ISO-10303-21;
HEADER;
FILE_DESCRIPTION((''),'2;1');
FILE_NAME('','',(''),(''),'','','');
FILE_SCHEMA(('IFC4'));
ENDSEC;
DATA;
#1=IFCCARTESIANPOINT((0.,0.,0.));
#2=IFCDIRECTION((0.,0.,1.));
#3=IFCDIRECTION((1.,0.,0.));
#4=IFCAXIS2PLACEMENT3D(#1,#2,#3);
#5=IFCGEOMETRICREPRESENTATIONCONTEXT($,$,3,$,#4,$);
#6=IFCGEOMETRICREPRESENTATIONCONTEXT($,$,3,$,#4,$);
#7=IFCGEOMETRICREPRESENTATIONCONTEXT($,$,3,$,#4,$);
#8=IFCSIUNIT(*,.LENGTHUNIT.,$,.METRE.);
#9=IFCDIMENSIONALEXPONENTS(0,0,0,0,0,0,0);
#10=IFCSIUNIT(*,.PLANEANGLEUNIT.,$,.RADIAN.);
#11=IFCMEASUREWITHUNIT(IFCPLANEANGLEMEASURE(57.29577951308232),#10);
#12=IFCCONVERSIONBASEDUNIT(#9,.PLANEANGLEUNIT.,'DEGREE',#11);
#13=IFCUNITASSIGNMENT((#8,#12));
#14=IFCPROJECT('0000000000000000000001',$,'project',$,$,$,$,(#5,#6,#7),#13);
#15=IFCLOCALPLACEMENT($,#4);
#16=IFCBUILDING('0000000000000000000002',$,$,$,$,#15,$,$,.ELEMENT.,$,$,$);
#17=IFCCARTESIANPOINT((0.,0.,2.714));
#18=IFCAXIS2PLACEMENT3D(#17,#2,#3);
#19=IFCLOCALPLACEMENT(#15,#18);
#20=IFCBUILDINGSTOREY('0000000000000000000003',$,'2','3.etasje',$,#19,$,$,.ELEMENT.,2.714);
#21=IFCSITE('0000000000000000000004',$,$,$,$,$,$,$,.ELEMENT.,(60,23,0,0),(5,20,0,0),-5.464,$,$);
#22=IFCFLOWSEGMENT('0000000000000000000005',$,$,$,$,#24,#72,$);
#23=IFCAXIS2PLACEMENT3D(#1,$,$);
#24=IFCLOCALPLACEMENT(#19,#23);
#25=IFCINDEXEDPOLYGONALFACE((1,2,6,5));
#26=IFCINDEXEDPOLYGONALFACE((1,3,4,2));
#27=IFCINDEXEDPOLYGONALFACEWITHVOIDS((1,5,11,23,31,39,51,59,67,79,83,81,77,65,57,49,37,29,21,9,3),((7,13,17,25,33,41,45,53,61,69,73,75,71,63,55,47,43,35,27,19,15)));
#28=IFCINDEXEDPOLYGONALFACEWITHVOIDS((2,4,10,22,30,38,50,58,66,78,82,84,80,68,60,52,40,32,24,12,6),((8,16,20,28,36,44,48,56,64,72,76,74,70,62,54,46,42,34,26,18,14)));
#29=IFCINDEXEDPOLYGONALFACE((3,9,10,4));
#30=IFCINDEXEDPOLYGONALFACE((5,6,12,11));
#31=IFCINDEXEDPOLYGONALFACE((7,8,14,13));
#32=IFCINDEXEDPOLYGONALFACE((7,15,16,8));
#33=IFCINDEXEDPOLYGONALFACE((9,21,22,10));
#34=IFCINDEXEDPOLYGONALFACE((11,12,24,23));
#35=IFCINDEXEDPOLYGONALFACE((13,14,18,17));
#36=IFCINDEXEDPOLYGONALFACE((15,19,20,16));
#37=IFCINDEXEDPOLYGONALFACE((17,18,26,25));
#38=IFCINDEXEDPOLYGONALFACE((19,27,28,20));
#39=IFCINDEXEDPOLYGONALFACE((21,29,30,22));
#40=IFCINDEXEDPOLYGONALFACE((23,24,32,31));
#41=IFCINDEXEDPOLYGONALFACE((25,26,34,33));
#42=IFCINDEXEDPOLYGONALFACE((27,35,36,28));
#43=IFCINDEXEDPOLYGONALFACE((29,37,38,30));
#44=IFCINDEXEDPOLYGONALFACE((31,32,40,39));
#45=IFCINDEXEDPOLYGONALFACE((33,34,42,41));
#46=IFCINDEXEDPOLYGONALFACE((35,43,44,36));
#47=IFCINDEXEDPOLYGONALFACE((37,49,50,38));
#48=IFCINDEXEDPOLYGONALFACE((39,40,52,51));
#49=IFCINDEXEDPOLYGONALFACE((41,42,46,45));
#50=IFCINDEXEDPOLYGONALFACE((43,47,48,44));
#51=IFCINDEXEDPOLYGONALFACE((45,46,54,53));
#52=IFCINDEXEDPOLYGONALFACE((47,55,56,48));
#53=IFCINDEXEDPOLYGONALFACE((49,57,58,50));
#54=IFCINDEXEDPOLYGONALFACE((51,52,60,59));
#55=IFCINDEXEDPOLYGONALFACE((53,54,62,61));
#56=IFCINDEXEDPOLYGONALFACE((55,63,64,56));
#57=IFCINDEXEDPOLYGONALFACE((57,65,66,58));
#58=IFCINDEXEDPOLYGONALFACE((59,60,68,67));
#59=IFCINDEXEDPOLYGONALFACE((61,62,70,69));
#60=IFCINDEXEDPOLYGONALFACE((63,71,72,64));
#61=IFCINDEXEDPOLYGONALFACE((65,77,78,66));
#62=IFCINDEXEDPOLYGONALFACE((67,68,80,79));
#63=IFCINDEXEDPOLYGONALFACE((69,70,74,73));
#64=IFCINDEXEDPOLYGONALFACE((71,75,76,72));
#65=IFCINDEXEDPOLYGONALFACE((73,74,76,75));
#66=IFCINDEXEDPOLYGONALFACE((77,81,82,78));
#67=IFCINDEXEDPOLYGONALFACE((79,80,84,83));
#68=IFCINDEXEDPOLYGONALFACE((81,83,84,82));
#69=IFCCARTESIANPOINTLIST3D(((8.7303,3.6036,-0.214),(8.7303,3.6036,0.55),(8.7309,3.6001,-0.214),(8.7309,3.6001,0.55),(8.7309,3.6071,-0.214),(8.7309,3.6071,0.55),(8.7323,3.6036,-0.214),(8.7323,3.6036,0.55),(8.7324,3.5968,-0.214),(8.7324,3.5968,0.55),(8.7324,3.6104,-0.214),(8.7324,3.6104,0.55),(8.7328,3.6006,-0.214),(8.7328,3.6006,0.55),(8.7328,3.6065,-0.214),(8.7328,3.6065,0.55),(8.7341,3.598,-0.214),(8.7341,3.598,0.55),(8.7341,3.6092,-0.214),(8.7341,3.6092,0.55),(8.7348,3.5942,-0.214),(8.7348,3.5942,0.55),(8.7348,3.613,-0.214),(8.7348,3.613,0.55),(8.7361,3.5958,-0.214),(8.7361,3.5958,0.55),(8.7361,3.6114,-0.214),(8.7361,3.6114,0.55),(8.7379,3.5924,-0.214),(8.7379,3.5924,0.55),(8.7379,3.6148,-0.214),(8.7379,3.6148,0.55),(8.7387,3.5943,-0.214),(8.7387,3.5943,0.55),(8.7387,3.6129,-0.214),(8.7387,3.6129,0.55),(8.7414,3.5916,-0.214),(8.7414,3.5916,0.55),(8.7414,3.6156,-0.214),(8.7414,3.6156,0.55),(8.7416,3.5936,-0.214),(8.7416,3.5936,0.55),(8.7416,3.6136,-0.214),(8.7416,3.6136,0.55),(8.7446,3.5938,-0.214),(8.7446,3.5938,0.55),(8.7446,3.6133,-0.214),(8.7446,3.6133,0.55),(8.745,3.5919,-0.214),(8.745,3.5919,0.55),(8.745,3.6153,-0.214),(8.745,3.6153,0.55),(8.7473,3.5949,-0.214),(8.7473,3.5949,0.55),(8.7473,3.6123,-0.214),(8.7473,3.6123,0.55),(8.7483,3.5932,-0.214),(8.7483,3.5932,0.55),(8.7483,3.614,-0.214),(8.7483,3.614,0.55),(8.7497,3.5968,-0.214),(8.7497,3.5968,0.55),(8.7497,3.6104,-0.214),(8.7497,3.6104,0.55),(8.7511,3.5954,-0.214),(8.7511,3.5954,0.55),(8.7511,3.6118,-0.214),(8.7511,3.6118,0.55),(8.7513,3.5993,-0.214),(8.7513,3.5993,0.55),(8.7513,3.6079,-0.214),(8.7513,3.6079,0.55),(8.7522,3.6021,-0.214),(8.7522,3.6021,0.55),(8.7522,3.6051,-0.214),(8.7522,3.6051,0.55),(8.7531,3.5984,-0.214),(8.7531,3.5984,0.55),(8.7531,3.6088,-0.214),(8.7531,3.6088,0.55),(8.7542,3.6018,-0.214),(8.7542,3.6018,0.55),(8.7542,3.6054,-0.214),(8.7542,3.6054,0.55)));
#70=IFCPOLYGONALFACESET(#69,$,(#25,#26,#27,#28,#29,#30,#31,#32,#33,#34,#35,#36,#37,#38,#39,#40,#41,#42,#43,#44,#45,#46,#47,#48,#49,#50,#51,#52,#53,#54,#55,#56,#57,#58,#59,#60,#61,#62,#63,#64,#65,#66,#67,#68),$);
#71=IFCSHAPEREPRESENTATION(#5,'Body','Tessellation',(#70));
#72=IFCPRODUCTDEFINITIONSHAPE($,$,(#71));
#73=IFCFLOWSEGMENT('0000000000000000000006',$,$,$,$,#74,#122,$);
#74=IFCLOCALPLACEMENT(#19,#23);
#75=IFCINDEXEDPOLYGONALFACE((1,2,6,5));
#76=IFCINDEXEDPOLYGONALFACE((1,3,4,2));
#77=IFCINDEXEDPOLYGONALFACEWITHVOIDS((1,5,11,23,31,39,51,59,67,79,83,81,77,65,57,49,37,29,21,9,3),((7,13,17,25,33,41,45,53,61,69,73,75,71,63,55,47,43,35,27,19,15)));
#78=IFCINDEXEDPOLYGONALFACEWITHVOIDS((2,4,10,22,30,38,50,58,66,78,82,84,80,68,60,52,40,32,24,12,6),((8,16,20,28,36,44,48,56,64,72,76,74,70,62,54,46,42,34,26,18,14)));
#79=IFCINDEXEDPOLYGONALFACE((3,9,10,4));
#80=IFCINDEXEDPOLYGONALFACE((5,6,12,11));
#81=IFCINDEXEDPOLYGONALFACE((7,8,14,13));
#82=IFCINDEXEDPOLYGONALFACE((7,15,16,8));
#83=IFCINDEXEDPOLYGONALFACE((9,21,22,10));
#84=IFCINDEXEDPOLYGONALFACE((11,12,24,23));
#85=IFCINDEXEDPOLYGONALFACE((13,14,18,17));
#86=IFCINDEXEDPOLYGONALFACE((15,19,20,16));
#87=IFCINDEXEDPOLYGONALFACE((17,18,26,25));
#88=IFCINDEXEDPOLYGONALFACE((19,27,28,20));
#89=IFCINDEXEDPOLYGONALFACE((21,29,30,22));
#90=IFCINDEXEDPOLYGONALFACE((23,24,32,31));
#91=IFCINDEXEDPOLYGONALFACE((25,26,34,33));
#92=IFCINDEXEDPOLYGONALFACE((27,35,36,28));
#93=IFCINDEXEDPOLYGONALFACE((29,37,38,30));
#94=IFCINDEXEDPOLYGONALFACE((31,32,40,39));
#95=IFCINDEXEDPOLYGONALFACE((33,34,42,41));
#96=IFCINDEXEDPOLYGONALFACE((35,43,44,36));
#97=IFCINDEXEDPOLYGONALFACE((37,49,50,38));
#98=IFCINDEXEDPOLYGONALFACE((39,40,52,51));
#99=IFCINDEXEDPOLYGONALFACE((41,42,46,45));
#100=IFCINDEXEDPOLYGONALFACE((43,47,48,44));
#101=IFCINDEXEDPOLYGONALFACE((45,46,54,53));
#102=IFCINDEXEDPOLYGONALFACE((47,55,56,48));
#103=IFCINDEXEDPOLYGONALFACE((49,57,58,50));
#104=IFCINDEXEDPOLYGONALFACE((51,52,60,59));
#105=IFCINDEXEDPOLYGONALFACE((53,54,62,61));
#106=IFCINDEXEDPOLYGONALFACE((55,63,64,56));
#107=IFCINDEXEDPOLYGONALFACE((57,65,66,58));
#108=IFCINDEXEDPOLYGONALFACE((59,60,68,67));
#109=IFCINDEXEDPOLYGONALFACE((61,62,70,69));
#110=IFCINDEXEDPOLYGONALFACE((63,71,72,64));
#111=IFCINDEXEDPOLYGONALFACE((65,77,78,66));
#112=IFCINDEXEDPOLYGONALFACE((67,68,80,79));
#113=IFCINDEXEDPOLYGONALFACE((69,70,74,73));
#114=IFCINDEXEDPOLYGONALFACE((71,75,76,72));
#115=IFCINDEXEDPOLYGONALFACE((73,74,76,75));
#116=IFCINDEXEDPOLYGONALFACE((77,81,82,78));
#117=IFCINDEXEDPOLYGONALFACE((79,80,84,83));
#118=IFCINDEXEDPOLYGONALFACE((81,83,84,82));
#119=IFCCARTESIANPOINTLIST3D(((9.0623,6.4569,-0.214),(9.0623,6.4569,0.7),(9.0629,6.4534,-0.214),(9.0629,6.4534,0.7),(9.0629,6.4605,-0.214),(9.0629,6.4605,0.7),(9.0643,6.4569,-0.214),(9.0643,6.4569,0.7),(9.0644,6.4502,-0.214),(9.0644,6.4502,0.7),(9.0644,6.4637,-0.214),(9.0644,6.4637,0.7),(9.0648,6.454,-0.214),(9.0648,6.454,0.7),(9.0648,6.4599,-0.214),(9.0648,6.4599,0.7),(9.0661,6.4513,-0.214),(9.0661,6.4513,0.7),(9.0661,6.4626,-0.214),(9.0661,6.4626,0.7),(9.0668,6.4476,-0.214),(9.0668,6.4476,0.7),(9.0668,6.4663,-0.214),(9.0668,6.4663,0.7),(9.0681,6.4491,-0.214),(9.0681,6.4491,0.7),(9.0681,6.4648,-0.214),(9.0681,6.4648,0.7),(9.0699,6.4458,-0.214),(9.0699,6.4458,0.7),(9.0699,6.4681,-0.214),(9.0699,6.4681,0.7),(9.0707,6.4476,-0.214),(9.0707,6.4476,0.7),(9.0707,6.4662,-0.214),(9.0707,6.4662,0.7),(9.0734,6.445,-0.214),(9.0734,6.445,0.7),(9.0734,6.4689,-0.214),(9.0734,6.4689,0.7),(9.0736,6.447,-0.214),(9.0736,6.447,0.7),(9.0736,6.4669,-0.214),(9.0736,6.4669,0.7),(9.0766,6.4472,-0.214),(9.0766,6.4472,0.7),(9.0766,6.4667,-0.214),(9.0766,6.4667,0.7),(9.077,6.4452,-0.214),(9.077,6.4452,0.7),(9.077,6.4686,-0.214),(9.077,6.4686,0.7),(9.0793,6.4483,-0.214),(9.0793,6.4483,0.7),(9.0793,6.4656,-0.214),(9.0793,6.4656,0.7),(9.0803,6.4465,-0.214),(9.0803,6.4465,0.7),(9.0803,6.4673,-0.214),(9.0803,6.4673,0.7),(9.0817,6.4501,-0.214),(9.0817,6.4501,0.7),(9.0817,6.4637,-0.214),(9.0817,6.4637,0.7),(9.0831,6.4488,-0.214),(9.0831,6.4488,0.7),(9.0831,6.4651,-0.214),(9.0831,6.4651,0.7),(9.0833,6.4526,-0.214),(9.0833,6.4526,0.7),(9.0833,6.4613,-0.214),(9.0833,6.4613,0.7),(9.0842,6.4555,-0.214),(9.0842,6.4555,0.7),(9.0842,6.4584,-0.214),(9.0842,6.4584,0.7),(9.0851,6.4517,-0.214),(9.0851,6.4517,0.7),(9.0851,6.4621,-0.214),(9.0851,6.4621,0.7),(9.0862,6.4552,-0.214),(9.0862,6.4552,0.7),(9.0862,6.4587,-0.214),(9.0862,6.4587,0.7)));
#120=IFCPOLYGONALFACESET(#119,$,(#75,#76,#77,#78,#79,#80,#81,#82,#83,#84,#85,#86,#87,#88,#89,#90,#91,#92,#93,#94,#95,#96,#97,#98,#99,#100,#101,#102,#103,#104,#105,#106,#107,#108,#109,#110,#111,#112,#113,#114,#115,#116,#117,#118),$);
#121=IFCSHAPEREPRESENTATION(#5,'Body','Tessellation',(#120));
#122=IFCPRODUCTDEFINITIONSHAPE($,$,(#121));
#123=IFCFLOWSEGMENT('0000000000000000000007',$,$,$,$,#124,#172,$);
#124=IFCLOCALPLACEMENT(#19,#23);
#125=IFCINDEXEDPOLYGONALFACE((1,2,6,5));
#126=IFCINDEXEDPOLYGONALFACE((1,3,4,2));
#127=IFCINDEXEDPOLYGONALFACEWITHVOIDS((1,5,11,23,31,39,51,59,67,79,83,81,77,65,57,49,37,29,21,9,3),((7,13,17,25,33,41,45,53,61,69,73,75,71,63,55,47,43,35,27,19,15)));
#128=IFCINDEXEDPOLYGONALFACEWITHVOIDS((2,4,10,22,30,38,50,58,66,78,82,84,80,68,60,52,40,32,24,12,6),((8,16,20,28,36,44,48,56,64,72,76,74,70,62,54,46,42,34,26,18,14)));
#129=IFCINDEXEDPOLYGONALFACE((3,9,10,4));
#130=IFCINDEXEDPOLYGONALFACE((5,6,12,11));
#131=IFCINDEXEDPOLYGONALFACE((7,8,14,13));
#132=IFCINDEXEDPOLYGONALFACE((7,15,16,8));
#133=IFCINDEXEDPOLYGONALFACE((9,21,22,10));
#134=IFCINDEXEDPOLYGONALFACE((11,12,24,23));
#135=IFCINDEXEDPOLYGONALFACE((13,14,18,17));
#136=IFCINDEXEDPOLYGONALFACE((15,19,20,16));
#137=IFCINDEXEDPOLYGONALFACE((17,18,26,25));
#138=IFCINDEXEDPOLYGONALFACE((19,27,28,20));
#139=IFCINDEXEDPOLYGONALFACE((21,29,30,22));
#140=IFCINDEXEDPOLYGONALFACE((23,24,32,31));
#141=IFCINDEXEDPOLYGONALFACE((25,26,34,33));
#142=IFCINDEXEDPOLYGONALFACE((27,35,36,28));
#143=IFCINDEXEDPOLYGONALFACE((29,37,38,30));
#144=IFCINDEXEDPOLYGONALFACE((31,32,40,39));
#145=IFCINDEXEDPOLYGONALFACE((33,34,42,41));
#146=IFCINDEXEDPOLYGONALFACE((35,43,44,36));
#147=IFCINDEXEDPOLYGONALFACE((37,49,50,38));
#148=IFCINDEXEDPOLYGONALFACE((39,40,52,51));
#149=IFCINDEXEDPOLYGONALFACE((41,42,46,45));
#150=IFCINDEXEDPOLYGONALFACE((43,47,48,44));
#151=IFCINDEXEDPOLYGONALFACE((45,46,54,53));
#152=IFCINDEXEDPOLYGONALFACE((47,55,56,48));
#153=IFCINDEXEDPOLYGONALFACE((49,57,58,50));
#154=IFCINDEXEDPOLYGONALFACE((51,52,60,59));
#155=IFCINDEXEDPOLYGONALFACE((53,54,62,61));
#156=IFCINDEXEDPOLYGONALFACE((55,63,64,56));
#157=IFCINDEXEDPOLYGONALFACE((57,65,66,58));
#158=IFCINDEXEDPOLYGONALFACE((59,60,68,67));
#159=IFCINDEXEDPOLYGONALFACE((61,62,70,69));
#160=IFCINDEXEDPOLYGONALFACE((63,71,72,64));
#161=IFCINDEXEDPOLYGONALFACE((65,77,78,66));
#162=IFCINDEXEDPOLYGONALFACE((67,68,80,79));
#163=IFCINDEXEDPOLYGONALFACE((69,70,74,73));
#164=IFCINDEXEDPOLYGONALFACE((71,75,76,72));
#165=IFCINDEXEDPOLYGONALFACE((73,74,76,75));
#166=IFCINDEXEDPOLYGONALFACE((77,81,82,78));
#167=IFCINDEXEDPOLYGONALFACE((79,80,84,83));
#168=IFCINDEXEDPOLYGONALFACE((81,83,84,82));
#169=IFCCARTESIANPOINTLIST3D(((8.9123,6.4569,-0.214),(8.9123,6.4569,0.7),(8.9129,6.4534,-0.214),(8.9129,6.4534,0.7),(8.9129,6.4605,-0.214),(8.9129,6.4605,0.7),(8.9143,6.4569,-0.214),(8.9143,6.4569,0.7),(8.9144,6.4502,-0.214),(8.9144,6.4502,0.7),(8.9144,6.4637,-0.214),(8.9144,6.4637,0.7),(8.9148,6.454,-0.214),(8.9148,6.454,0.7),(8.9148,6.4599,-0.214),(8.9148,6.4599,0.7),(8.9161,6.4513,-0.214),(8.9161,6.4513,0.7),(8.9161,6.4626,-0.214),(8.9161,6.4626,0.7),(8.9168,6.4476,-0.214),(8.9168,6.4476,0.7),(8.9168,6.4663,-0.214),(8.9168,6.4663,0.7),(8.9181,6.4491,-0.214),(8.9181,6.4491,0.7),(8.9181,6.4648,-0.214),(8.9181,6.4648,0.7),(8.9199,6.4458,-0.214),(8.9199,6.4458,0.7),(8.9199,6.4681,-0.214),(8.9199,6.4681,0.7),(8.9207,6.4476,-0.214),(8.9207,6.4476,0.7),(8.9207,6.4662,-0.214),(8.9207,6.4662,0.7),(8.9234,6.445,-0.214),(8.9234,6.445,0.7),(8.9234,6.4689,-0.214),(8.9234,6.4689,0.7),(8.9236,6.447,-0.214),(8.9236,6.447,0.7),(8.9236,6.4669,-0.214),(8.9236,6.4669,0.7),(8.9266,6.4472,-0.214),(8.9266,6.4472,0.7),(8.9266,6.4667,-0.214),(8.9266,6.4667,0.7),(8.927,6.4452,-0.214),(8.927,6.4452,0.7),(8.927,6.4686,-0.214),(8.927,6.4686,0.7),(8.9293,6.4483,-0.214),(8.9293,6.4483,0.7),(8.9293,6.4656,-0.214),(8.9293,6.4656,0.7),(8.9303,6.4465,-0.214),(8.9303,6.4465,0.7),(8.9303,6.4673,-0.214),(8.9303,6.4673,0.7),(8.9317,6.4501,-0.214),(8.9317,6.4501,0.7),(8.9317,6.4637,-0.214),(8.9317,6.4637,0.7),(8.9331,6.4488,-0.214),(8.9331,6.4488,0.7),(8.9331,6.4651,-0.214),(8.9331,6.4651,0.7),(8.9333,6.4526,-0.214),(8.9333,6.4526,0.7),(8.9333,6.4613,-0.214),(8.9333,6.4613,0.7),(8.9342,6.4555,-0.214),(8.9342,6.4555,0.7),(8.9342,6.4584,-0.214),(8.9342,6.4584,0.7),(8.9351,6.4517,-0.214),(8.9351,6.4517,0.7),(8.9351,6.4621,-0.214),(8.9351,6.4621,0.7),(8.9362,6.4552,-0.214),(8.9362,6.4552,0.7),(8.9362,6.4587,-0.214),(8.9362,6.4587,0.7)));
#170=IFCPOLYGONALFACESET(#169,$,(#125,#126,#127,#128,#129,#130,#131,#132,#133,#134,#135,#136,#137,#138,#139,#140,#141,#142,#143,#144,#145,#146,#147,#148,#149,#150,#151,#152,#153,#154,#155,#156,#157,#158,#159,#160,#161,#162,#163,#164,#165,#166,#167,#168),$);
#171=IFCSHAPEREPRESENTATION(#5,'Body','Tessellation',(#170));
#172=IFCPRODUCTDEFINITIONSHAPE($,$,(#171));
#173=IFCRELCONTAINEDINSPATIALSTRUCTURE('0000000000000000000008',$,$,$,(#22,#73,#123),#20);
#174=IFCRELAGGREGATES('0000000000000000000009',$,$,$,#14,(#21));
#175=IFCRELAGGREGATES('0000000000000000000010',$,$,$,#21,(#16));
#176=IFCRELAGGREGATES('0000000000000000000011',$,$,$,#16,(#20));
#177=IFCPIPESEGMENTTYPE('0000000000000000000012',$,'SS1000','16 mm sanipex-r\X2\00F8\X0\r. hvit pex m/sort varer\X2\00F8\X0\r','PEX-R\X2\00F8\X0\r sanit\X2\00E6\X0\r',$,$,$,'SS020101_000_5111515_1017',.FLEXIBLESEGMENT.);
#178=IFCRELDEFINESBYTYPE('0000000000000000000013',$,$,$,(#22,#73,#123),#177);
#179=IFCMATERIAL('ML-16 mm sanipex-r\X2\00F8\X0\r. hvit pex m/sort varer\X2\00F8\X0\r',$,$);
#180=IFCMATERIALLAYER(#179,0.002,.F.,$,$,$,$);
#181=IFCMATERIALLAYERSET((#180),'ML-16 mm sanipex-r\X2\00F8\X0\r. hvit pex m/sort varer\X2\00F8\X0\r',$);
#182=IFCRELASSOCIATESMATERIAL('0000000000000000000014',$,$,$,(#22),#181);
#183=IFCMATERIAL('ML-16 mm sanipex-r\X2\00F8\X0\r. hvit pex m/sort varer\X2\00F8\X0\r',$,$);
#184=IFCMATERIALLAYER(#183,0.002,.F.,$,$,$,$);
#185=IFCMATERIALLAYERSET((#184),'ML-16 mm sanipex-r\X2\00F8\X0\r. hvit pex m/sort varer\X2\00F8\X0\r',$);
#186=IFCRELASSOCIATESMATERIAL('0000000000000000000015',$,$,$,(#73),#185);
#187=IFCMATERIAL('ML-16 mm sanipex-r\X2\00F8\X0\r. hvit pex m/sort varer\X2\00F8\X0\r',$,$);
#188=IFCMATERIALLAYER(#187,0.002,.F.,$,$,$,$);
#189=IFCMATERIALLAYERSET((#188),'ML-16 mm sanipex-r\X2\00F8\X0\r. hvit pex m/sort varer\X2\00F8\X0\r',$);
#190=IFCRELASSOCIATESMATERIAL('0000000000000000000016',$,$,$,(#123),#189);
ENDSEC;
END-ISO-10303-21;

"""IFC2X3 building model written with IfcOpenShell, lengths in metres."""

from ifc_helpers import new_model, entity, si_unit, converted_unit, frame, origin_with_axes, origin_2d_with_axis, place, context, project, spatial, hollow_circle, extrude, material, layer, layer_set, layer_usage, type_object, element, save


model = new_model("IFC2X3")

# Units and contexts
context_of_model_1 = context(None, 3, world=origin_with_axes())
context_of_model_2 = context(None, 3, world=origin_with_axes())
context_of_model_3 = context(None, 3, world=origin_with_axes())
ifc_project = project(units=[si_unit("LENGTHUNIT", "METRE"), converted_unit("PLANEANGLEUNIT", "DEGREE", entity("IfcPlaneAngleMeasure", 57.29577951308232), si_unit("PLANEANGLEUNIT", "RADIAN"), dimensions=[0, 0, 0, 0, 0, 0, 0])], contexts=[context_of_model_1, context_of_model_2, context_of_model_3])

# Site, building, storey
site = spatial("IfcSite", under=ifc_project, CompositionType="ELEMENT", RefLatitude=(60, 23, 0, 0), RefLongitude=(5, 20, 0, 0), RefElevation=-5.464)
building_placement = place(None, origin_with_axes())
building = spatial("IfcBuilding", under=site, at=building_placement, CompositionType="ELEMENT")
storey_placement = place(building_placement, frame((0.0, 0.0, 2.714), z_axis=(0.0, 0.0, 1.0), x_axis=(1.0, 0.0, 0.0)))
storey = spatial("IfcBuildingStorey", under=building, at=storey_placement, Name="2", Description="3.etasje", CompositionType="ELEMENT", Elevation=2.714)

# Flow segments
pipe_segment_type_1 = type_object("IfcPipeSegmentType", Name="SS1000", Description="16 mm sanipex-rør. hvit pex m/sort varerør", ApplicableOccurrence="PEX-Rør sanitær", ElementType="SS020101_000_5111515_1017", PredefinedType="FLEXIBLESEGMENT")
ifc_material_1 = material(Name="ML-16 mm sanipex-rør. hvit pex m/sort varerør")
ifc_layer_1 = layer(ifc_material_1, 0.002, ventilated=False)
ifc_layer_set_1 = layer_set([ifc_layer_1], Name="ML-16 mm sanipex-rør. hvit pex m/sort varerør")
ifc_layer_usage_1 = layer_usage(ifc_layer_set_1, "AXIS2", "POSITIVE", 0.0)
flow_segment_1_placement = place(storey_placement, frame((8.7423, 3.6036, 0.55), z_axis=(0.0, 0.0, -1.0), x_axis=(-1.0, 0.0, 0.0)))
element("IfcFlowSegment", 1, at=flow_segment_1_placement, inside=storey, type_object=pipe_segment_type_1, material=ifc_layer_usage_1, context=context_of_model_1, shape_type="SweptSolid", body=[
    extrude(hollow_circle(Radius=0.012, WallThickness=0.002, at=origin_2d_with_axis()), origin_with_axes(), (0.0, 0.0, 1.0), 0.764),
])
ifc_material_2 = material(Name="ML-16 mm sanipex-rør. hvit pex m/sort varerør")
ifc_layer_2 = layer(ifc_material_2, 0.002, ventilated=False)
ifc_layer_set_2 = layer_set([ifc_layer_2], Name="ML-16 mm sanipex-rør. hvit pex m/sort varerør")
ifc_layer_usage_2 = layer_usage(ifc_layer_set_2, "AXIS2", "POSITIVE", 0.0)
flow_segment_2_placement = place(storey_placement, frame((9.0743, 6.4569, 0.7), z_axis=(0.0, 0.0, -1.0), x_axis=(-1.0, 0.0, 0.0)))
element("IfcFlowSegment", 2, at=flow_segment_2_placement, inside=storey, type_object=pipe_segment_type_1, material=ifc_layer_usage_2, context=context_of_model_1, shape_type="SweptSolid", body=[
    extrude(hollow_circle(Radius=0.012, WallThickness=0.002, at=origin_2d_with_axis()), origin_with_axes(), (0.0, 0.0, 1.0), 0.914),
])
ifc_material_3 = material(Name="ML-16 mm sanipex-rør. hvit pex m/sort varerør")
ifc_layer_3 = layer(ifc_material_3, 0.002, ventilated=False)
ifc_layer_set_3 = layer_set([ifc_layer_3], Name="ML-16 mm sanipex-rør. hvit pex m/sort varerør")
ifc_layer_usage_3 = layer_usage(ifc_layer_set_3, "AXIS2", "POSITIVE", 0.0)
flow_segment_3_placement = place(storey_placement, frame((8.9243, 6.4569, 0.7), z_axis=(0.0, 0.0, -1.0), x_axis=(-1.0, 0.0, 0.0)))
element("IfcFlowSegment", 3, at=flow_segment_3_placement, inside=storey, type_object=pipe_segment_type_1, material=ifc_layer_usage_3, context=context_of_model_1, shape_type="SweptSolid", body=[
    extrude(hollow_circle(Radius=0.012, WallThickness=0.002, at=origin_2d_with_axis()), origin_with_axes(), (0.0, 0.0, 1.0), 0.914),
])

save(model, "model.ifc")
